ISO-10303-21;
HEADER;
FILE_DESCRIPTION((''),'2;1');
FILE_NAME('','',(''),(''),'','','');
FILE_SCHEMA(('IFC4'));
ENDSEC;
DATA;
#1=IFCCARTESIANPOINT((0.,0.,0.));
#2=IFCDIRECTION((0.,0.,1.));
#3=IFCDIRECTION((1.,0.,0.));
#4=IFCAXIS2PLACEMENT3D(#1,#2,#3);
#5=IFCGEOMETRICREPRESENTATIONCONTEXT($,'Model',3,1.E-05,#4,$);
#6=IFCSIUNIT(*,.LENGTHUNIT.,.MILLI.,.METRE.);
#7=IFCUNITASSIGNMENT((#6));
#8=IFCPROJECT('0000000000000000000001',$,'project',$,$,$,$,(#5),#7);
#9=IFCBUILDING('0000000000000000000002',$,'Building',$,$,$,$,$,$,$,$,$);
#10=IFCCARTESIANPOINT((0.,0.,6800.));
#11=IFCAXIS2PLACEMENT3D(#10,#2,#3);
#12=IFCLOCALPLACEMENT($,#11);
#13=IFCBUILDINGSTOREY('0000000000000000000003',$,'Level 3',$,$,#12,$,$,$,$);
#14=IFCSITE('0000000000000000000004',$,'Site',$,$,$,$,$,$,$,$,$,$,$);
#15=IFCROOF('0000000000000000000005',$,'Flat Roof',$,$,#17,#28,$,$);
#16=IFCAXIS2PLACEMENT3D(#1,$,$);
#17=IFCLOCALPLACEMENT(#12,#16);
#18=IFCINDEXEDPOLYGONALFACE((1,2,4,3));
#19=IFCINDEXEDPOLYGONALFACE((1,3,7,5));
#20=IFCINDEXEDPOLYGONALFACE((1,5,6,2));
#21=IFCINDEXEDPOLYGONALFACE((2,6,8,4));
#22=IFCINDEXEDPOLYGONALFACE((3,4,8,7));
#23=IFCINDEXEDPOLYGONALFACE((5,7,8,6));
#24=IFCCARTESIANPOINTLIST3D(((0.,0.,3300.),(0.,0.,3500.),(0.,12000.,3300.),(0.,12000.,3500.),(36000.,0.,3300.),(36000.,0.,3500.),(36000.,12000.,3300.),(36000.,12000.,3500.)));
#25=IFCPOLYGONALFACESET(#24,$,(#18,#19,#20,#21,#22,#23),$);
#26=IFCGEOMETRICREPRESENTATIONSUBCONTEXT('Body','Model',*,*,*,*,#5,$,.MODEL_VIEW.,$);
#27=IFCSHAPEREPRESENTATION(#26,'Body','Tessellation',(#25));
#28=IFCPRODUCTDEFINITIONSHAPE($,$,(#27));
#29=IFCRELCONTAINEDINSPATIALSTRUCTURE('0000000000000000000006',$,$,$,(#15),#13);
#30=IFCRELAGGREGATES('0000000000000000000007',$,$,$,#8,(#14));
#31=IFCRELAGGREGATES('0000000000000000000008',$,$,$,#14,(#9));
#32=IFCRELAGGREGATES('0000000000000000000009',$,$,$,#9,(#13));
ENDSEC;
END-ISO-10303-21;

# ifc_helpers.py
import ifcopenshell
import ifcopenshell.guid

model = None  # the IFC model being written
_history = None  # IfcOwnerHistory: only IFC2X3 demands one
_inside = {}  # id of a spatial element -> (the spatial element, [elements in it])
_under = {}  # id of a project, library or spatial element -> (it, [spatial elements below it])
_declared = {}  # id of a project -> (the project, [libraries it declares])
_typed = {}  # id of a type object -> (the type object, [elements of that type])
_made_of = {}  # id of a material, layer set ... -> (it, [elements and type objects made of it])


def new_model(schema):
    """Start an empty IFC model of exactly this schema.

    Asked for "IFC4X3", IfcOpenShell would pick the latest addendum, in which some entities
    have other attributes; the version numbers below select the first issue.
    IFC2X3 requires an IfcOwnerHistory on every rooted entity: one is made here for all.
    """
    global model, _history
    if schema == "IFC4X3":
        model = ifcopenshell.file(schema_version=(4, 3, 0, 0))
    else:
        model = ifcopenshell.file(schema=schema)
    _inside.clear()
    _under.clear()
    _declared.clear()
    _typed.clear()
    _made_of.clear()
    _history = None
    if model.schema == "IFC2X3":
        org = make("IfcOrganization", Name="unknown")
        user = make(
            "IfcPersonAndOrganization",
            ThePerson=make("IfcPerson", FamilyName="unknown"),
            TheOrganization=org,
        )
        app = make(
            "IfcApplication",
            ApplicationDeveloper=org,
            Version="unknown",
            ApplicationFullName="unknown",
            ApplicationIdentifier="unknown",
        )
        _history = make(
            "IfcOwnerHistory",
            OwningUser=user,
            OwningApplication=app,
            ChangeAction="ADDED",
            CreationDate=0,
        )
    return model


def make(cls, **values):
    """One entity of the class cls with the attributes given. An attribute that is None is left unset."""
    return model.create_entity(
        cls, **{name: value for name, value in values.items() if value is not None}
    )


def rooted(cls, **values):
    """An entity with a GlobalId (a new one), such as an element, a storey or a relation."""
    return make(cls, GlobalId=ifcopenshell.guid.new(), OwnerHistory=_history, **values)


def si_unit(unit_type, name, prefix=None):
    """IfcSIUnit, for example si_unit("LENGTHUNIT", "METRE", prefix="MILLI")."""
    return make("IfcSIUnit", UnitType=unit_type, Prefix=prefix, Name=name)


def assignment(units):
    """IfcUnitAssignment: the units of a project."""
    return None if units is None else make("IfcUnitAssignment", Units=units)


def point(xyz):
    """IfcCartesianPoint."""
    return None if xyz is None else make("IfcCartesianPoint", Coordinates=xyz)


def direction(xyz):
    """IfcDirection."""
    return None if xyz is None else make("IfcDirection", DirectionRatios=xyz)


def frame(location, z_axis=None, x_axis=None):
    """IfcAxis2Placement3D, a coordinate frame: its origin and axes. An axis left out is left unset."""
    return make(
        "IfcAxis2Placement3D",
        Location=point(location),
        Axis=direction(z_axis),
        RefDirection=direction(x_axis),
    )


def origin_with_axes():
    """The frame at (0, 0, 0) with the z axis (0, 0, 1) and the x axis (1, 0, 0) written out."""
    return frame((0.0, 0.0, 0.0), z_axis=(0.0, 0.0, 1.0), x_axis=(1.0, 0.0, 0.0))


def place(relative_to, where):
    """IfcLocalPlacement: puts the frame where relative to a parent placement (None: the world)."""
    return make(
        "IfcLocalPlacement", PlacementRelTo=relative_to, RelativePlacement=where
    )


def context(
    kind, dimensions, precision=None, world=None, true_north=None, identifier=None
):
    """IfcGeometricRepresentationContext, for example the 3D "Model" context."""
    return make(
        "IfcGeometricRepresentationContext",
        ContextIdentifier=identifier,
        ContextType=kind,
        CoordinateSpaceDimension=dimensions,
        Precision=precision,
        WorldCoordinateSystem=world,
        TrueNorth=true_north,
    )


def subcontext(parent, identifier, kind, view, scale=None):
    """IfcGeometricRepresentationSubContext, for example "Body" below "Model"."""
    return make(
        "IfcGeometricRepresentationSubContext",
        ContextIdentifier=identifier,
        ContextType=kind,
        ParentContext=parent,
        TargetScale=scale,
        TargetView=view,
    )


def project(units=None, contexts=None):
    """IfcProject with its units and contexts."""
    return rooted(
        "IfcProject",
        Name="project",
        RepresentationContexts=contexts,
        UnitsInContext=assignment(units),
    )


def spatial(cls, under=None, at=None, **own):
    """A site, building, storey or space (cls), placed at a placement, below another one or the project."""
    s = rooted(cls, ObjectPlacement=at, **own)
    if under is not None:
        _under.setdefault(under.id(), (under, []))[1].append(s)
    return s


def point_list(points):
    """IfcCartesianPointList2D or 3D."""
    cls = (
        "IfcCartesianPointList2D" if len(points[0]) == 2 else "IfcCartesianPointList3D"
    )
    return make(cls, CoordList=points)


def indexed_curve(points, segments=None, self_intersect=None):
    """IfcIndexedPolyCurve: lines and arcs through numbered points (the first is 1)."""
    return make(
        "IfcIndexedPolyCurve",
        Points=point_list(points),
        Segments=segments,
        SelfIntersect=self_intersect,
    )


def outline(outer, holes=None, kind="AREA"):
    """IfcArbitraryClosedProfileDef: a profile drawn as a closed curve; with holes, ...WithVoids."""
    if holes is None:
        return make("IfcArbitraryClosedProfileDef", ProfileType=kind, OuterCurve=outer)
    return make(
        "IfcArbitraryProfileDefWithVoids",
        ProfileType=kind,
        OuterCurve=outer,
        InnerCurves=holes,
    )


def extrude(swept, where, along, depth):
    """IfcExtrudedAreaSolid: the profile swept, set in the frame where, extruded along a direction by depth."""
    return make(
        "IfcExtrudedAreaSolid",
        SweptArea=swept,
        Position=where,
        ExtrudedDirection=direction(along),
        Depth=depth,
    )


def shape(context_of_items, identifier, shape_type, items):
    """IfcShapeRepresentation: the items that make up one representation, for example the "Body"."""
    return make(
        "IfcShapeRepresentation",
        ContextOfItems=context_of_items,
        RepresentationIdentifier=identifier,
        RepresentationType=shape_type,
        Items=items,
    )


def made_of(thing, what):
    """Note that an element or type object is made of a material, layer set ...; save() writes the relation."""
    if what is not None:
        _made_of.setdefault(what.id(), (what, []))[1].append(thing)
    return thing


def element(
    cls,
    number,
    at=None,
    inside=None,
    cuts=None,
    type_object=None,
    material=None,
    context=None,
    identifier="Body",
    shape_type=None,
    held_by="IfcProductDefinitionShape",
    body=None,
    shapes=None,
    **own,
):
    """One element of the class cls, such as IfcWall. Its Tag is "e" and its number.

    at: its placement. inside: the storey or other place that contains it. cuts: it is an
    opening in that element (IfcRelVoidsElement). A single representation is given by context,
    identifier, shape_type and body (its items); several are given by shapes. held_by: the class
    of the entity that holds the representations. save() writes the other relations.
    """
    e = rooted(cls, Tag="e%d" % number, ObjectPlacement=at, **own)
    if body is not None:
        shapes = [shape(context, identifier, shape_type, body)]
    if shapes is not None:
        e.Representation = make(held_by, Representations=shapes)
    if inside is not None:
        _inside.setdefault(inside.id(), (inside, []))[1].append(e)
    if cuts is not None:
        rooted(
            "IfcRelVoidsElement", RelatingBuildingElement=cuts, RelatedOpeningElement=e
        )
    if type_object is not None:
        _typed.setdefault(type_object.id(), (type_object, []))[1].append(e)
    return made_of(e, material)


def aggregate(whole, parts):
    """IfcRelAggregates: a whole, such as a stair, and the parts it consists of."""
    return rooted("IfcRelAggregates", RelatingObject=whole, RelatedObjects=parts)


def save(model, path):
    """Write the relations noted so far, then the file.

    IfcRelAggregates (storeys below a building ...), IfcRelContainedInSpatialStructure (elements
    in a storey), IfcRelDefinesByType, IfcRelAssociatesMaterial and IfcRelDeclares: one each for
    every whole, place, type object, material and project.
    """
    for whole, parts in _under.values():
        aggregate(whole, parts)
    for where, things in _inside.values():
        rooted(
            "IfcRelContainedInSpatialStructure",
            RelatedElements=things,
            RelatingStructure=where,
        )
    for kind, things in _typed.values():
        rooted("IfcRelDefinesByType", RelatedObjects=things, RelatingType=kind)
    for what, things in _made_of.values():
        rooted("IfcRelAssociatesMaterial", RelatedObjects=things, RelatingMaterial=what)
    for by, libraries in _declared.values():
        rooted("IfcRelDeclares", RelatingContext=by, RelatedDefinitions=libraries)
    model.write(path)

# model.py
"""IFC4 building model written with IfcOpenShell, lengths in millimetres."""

from ifc_helpers import new_model, si_unit, frame, origin_with_axes, place, context, subcontext, project, spatial, indexed_curve, outline, extrude, element, save


model = new_model("IFC4")

# Units and contexts
model_context = context("Model", 3, precision=1e-05, world=origin_with_axes())
body_context = subcontext(model_context, "Body", "Model", "MODEL_VIEW")
ifc_project = project(units=[si_unit("LENGTHUNIT", "METRE", prefix="MILLI")], contexts=[model_context])

# Site, building, storey
site = spatial("IfcSite", under=ifc_project, Name="Site")
building = spatial("IfcBuilding", under=site, Name="Building")
storey_placement = place(None, frame((0.0, 0.0, 6800.0), z_axis=(0.0, 0.0, 1.0), x_axis=(1.0, 0.0, 0.0)))
storey = spatial("IfcBuildingStorey", under=building, at=storey_placement, Name="Level 3")

# Roof
roof_placement = place(storey_placement, frame((0.0, 0.0, 3300.0), z_axis=(0.0, 0.0, 1.0), x_axis=(1.0, 0.0, 0.0)))
element("IfcRoof", 1, at=roof_placement, inside=storey, Name="Flat Roof", context=body_context, shape_type="SweptSolid", body=[
    extrude(outline(indexed_curve([(0.0, 0.0), (36000.0, 0.0), (36000.0, 12000.0), (0.0, 12000.0), (0.0, 0.0)])), None, (0.0, 0.0, 1.0), 200.0),
])

save(model, "model.ifc")
